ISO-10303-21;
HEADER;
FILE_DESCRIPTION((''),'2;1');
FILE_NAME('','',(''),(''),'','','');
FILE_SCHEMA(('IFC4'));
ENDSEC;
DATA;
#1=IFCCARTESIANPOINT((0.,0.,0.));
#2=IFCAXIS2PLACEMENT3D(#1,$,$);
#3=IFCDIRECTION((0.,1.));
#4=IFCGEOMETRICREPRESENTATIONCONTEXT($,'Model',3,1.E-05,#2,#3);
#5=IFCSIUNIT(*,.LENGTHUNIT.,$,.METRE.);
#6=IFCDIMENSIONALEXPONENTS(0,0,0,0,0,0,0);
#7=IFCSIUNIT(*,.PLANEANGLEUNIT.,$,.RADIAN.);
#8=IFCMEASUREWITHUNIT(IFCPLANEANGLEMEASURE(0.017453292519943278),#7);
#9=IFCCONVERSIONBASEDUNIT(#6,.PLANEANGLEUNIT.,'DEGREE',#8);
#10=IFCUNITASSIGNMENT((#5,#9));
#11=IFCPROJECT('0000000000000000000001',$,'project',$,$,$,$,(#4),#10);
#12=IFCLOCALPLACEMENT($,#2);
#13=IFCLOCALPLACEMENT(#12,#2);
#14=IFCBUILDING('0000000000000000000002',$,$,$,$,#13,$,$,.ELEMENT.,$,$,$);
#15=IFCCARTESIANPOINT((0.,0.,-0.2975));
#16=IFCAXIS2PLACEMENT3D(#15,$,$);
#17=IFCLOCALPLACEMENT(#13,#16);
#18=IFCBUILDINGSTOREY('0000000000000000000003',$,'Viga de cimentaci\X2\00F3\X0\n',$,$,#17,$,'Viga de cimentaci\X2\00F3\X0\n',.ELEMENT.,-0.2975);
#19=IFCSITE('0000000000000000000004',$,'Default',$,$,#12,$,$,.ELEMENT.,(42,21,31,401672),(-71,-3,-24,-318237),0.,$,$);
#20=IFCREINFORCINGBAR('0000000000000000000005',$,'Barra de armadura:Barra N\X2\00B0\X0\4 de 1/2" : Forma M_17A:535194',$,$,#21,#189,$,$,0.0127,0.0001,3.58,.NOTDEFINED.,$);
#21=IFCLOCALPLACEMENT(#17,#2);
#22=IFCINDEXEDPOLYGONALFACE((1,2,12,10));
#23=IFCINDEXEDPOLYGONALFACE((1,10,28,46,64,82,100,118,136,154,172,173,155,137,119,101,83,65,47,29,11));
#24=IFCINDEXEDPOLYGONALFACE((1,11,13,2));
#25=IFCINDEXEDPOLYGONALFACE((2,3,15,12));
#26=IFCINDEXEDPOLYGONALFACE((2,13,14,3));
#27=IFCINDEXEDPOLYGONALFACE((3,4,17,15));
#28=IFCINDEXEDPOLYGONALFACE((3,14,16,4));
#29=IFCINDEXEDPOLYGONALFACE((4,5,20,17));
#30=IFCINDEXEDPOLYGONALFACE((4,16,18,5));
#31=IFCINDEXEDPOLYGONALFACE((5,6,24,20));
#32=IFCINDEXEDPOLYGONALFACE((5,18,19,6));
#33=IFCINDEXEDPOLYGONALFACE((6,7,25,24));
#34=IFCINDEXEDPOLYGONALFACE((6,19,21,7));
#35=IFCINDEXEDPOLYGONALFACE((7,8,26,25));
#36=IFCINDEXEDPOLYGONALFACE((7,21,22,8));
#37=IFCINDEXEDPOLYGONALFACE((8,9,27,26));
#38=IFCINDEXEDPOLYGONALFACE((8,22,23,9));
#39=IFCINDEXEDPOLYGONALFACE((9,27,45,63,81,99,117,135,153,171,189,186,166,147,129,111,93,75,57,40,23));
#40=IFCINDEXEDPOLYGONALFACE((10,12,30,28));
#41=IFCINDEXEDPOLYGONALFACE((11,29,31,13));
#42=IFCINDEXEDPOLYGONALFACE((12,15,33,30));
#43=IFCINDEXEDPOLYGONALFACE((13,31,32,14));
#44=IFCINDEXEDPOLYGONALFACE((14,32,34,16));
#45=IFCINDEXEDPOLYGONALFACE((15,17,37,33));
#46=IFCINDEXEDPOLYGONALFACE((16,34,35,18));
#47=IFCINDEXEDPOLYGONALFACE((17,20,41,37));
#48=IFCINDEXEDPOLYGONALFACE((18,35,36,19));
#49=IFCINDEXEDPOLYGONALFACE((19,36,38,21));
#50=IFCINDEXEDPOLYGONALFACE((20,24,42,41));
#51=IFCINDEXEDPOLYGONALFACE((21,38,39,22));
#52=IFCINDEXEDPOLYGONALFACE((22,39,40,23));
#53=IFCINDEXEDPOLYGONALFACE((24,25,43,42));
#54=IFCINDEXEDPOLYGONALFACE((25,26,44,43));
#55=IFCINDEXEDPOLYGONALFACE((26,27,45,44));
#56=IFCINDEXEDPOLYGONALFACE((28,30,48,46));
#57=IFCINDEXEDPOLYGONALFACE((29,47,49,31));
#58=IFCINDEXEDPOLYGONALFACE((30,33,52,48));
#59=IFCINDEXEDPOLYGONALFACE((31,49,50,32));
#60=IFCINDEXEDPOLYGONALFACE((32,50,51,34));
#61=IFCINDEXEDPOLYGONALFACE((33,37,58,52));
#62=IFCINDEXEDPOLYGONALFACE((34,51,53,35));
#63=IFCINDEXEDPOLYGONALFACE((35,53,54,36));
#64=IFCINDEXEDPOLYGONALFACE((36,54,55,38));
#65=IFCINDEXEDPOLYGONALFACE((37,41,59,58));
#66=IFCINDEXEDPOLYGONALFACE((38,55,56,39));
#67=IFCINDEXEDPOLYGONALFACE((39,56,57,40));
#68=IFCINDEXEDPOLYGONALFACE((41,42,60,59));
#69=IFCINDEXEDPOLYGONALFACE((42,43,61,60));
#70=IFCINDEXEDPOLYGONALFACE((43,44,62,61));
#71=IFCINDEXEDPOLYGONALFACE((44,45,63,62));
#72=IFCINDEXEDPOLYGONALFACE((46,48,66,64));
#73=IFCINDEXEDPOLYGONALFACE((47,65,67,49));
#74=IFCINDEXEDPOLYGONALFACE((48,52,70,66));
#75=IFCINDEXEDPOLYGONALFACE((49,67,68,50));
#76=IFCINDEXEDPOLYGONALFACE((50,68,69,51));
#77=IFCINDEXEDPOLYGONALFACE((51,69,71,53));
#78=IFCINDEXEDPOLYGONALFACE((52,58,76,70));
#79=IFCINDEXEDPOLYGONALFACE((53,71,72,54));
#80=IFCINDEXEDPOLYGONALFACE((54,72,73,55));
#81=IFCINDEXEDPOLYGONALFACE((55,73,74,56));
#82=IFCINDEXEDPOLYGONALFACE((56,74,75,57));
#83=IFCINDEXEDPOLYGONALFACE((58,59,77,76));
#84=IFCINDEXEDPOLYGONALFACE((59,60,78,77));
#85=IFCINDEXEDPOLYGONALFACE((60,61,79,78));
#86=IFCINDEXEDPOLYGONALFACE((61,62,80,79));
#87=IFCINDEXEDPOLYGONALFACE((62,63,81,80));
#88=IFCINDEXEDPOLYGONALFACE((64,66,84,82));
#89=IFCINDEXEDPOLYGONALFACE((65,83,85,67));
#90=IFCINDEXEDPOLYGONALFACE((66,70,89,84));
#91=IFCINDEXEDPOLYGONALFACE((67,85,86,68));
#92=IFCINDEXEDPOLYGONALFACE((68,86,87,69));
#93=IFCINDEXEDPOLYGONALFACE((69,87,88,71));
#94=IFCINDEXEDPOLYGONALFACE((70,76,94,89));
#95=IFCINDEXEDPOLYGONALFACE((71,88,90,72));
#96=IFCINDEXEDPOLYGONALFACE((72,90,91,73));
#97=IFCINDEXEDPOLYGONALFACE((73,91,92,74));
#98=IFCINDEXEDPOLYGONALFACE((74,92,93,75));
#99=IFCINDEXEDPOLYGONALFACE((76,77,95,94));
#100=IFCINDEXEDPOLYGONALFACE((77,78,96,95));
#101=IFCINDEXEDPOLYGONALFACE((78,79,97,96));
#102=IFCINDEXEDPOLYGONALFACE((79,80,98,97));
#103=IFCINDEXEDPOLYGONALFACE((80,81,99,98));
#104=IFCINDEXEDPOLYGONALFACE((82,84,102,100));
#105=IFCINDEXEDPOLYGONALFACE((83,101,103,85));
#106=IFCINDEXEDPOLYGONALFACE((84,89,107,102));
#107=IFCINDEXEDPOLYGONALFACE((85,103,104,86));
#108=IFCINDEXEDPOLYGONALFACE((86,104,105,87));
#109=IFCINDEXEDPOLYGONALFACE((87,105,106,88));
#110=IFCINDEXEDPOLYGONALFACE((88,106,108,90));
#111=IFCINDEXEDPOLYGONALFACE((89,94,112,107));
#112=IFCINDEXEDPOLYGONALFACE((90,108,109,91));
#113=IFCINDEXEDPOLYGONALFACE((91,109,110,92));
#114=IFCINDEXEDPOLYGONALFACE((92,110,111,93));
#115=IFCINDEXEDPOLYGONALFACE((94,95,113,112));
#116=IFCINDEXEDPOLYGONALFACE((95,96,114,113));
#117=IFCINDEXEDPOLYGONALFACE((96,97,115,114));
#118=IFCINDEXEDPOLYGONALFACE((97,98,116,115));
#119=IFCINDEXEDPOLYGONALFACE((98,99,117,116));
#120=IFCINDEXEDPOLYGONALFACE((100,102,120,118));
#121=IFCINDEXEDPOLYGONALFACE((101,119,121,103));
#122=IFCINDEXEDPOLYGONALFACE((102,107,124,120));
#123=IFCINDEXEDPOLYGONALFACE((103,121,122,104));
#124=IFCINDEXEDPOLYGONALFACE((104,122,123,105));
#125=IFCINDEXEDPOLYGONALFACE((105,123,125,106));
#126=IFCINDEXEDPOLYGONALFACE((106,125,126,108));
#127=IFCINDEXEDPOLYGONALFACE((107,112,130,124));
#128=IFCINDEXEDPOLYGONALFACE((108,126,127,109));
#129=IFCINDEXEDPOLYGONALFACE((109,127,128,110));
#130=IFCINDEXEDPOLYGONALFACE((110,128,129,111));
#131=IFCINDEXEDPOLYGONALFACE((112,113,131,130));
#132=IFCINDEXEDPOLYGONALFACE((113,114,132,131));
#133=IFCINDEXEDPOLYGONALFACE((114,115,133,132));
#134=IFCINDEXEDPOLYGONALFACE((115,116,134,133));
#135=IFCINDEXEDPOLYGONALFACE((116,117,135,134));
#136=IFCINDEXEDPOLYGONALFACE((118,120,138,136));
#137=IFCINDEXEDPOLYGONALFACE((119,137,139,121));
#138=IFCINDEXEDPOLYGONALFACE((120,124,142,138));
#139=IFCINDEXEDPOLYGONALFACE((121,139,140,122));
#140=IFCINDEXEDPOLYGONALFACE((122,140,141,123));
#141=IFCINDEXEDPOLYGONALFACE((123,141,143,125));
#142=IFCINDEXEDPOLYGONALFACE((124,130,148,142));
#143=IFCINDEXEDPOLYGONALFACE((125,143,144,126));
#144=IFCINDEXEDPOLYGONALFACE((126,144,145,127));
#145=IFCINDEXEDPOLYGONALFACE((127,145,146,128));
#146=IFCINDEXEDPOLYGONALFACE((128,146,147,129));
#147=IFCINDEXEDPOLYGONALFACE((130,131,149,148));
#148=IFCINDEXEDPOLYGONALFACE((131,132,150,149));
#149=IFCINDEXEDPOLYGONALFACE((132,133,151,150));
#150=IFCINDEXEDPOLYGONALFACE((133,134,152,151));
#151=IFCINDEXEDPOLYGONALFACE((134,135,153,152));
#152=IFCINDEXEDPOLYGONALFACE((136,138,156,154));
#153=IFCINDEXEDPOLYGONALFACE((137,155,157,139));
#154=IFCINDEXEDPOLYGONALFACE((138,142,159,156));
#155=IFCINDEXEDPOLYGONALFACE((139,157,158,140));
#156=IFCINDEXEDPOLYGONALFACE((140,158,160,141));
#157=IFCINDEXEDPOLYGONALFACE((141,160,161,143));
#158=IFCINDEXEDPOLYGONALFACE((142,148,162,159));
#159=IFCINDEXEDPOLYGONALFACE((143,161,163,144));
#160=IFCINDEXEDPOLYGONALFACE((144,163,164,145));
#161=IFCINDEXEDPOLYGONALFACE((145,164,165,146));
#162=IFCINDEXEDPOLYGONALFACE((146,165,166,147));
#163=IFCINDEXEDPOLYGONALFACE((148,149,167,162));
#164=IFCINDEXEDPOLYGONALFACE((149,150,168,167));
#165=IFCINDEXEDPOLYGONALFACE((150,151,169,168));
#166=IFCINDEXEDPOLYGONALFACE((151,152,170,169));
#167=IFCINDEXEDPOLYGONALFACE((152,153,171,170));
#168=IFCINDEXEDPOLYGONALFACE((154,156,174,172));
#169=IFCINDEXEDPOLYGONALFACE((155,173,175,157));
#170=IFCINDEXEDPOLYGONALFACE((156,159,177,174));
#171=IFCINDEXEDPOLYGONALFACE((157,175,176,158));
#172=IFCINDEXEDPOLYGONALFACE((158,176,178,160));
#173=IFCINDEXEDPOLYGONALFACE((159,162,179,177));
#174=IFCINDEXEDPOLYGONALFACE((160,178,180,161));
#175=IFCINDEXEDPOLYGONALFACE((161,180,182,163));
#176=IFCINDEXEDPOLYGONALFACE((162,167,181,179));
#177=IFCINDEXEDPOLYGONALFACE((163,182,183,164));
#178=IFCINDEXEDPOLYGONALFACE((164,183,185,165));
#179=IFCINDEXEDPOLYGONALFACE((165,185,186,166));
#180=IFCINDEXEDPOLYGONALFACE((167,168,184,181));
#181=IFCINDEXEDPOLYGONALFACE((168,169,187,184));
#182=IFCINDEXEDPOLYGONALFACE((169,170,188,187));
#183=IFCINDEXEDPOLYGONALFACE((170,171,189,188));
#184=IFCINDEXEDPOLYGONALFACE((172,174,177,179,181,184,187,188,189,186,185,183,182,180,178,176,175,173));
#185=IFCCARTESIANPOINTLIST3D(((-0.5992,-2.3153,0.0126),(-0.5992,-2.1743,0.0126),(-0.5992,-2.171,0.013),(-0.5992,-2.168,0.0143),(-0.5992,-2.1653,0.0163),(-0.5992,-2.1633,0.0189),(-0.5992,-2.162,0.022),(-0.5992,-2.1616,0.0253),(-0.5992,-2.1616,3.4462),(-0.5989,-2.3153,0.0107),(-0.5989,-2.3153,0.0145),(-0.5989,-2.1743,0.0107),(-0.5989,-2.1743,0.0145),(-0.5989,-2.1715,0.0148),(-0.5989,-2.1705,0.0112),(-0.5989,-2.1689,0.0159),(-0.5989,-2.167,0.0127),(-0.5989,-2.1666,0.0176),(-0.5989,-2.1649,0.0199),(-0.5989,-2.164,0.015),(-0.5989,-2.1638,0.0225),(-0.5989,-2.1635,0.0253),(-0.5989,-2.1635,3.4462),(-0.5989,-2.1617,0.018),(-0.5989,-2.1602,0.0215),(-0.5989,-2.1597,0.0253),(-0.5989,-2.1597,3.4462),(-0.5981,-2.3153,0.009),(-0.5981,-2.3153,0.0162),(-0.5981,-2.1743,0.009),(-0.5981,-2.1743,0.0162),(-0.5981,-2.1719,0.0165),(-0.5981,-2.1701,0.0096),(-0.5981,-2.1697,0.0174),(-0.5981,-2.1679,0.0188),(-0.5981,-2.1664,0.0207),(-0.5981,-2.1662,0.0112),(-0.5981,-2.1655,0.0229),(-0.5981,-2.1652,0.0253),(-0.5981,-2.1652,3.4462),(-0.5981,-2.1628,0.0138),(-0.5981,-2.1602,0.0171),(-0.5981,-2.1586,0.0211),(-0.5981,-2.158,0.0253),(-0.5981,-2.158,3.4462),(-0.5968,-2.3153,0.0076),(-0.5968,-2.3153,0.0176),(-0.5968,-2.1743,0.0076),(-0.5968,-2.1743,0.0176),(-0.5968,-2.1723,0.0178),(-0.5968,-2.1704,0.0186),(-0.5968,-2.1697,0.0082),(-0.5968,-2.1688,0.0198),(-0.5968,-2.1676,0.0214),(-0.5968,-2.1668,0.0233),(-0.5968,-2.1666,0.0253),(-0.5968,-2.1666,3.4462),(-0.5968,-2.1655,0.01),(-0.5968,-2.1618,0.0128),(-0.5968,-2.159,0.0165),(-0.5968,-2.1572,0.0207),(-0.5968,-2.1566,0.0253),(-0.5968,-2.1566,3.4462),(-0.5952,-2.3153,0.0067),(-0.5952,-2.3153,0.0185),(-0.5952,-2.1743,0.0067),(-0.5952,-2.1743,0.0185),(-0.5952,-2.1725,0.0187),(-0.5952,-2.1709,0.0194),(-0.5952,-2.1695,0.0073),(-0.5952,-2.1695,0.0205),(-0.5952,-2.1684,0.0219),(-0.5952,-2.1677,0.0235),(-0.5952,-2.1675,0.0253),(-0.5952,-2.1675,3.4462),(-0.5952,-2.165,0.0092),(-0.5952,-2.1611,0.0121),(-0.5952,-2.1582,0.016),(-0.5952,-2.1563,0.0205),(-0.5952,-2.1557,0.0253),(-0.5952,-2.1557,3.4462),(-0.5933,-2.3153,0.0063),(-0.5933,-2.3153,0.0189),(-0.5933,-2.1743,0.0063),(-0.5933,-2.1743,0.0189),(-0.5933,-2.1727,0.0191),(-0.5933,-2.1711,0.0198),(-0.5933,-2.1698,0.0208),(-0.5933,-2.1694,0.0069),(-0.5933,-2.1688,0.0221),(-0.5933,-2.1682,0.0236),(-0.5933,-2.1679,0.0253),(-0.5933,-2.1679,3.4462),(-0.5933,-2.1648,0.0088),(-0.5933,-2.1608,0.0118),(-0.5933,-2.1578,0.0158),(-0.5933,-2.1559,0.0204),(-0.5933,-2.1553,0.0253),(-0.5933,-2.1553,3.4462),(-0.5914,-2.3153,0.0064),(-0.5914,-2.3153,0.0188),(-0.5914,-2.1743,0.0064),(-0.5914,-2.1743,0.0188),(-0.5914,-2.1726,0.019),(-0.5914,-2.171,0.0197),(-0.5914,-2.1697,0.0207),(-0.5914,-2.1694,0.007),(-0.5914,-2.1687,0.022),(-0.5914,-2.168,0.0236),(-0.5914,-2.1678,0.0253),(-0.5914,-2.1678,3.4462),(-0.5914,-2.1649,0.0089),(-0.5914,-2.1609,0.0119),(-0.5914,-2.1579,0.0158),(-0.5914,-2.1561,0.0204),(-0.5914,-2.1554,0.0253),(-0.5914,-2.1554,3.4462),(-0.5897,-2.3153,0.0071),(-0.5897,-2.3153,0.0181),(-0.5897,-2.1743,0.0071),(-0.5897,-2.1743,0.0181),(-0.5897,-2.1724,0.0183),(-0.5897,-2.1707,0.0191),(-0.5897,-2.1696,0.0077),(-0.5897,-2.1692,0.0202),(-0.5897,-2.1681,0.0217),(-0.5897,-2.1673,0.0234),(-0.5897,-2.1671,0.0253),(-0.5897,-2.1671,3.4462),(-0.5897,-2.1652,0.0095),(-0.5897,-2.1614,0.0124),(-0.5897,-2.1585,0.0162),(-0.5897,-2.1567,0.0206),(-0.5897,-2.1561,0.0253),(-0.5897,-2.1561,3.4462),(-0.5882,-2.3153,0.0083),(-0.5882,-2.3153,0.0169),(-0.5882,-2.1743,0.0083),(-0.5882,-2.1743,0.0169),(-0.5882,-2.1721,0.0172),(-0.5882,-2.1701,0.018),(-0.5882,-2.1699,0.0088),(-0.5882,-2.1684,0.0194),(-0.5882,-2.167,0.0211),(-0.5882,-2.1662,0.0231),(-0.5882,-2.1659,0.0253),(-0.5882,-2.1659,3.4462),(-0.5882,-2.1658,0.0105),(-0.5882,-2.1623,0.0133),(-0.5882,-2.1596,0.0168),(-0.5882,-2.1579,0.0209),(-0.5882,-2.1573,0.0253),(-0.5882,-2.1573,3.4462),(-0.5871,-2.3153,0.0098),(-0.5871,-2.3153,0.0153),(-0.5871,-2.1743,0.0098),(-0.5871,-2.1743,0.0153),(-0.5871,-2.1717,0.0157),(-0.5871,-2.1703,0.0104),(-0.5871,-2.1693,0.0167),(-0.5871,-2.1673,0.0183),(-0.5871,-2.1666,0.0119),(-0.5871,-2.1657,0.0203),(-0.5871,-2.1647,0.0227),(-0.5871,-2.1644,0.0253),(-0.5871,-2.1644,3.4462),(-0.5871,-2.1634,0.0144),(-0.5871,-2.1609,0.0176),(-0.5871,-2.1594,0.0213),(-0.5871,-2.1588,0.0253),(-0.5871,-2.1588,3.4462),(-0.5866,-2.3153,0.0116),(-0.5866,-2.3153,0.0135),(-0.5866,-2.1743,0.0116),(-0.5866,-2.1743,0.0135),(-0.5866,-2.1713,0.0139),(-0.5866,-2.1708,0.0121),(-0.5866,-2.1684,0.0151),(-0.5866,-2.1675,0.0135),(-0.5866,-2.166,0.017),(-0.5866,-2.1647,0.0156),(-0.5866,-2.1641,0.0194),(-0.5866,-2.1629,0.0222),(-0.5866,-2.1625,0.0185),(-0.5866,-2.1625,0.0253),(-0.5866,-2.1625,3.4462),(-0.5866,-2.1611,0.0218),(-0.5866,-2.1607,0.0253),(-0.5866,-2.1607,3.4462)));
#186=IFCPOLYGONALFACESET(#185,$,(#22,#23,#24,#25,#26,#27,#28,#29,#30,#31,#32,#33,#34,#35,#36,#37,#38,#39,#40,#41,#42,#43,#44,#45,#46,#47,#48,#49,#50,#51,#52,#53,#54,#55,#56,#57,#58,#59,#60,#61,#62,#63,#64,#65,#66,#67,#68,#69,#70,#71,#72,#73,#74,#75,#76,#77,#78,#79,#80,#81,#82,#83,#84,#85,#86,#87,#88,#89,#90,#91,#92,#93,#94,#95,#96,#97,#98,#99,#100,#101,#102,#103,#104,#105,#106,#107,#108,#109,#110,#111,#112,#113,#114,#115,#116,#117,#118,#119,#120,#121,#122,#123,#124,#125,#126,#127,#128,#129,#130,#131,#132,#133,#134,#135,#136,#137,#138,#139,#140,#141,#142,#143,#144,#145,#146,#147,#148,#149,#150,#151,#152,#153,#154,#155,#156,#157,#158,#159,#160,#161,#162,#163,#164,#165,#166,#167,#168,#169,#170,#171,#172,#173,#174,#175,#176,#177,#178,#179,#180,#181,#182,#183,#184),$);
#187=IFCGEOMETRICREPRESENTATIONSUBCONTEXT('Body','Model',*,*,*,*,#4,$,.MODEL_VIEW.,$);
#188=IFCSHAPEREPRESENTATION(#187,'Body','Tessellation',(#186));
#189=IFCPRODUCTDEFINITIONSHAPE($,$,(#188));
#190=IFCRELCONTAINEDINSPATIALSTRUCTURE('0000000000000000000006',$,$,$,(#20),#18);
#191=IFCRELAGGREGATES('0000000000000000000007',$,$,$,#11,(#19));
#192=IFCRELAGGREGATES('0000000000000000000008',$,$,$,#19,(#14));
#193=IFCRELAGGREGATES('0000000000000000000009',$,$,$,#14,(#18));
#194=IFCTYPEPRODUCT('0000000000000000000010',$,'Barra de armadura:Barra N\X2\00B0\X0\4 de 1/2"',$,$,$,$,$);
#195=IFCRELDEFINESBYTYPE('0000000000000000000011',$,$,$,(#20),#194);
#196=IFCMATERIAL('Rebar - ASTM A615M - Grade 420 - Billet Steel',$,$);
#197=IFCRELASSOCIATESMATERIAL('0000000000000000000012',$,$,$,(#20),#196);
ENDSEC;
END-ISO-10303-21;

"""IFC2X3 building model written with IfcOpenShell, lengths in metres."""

from ifc_helpers import new_model, entity, si_unit, converted_unit, direction, frame, origin, place, context, subcontext, project, spatial, material, type_object, element, save


model = new_model("IFC2X3")

# Units and contexts
model_context = context("Model", 3, precision=1e-05, world=origin(), true_north=direction((0.0, 1.0)))
body_context = subcontext(model_context, "Body", "Model", "MODEL_VIEW")
ifc_project = project(units=[si_unit("LENGTHUNIT", "METRE"), converted_unit("PLANEANGLEUNIT", "DEGREE", entity("IfcPlaneAngleMeasure", 0.017453292519943278), si_unit("PLANEANGLEUNIT", "RADIAN"), dimensions=[0, 0, 0, 0, 0, 0, 0])], contexts=[model_context])

# Site, building, storey
site_placement = place(None, origin())
site = spatial("IfcSite", under=ifc_project, at=site_placement, Name="Default", CompositionType="ELEMENT", RefLatitude=(42, 21, 31, 401672), RefLongitude=(-71, -3, -24, -318237), RefElevation=0.0)
building_placement = place(site_placement, origin())
building = spatial("IfcBuilding", under=site, at=building_placement, CompositionType="ELEMENT")
storey_placement = place(building_placement, frame((0.0, 0.0, -0.2975)))
storey = spatial("IfcBuildingStorey", under=building, at=storey_placement, Name="Viga de cimentación", LongName="Viga de cimentación", CompositionType="ELEMENT", Elevation=-0.2975)

# Reinforcing bar
ifc_material = material(Name="Rebar - ASTM A615M - Grade 420 - Billet Steel")
type_product_1 = type_object("IfcTypeProduct", Name="Barra de armadura:Barra N°4 de 1/2\"")
reinforcing_bar_1_placement = place(storey_placement, origin())
element("IfcReinforcingBar", 1, at=reinforcing_bar_1_placement, inside=storey, type_object=type_product_1, material=ifc_material, Name="Barra de armadura:Barra N°4 de 1/2\" : Forma M_17A:535194", BarLength=3.58, BarRole="NOTDEFINED", CrossSectionArea=0.0001, NominalDiameter=0.0127, context=body_context, shape_type="AdvancedSweptSolid", body=[
    entity("IfcSweptDiskSolid", entity("IfcCompositeCurve", [entity("IfcCompositeCurveSegment", "CONTINUOUS", True, entity("IfcPolyline", [entity("IfcCartesianPoint", [-0.5929, -2.1616, 3.4462]), entity("IfcCartesianPoint", [-0.5929, -2.1616, 0.0253])])), entity("IfcCompositeCurveSegment", "CONTINUOUS", True, entity("IfcTrimmedCurve", entity("IfcCircle", entity("IfcAxis2Placement3D", entity("IfcCartesianPoint", [-0.5929, -2.1743, 0.0253]), entity("IfcDirection", [-1.0, 0.0, 0.0]), entity("IfcDirection", [0.0, 0.0, -1.0])), 0.0127), [entity("IfcParameterValue", 270.0)], [entity("IfcParameterValue", 360.0)], True, "PARAMETER")), entity("IfcCompositeCurveSegment", "CONTINUOUS", True, entity("IfcPolyline", [entity("IfcCartesianPoint", [-0.5929, -2.1743, 0.0126]), entity("IfcCartesianPoint", [-0.5929, -2.3153, 0.0126])]))], False), 0.0063, None, 0.0, 92.0),
])

save(model, "model.ifc")
